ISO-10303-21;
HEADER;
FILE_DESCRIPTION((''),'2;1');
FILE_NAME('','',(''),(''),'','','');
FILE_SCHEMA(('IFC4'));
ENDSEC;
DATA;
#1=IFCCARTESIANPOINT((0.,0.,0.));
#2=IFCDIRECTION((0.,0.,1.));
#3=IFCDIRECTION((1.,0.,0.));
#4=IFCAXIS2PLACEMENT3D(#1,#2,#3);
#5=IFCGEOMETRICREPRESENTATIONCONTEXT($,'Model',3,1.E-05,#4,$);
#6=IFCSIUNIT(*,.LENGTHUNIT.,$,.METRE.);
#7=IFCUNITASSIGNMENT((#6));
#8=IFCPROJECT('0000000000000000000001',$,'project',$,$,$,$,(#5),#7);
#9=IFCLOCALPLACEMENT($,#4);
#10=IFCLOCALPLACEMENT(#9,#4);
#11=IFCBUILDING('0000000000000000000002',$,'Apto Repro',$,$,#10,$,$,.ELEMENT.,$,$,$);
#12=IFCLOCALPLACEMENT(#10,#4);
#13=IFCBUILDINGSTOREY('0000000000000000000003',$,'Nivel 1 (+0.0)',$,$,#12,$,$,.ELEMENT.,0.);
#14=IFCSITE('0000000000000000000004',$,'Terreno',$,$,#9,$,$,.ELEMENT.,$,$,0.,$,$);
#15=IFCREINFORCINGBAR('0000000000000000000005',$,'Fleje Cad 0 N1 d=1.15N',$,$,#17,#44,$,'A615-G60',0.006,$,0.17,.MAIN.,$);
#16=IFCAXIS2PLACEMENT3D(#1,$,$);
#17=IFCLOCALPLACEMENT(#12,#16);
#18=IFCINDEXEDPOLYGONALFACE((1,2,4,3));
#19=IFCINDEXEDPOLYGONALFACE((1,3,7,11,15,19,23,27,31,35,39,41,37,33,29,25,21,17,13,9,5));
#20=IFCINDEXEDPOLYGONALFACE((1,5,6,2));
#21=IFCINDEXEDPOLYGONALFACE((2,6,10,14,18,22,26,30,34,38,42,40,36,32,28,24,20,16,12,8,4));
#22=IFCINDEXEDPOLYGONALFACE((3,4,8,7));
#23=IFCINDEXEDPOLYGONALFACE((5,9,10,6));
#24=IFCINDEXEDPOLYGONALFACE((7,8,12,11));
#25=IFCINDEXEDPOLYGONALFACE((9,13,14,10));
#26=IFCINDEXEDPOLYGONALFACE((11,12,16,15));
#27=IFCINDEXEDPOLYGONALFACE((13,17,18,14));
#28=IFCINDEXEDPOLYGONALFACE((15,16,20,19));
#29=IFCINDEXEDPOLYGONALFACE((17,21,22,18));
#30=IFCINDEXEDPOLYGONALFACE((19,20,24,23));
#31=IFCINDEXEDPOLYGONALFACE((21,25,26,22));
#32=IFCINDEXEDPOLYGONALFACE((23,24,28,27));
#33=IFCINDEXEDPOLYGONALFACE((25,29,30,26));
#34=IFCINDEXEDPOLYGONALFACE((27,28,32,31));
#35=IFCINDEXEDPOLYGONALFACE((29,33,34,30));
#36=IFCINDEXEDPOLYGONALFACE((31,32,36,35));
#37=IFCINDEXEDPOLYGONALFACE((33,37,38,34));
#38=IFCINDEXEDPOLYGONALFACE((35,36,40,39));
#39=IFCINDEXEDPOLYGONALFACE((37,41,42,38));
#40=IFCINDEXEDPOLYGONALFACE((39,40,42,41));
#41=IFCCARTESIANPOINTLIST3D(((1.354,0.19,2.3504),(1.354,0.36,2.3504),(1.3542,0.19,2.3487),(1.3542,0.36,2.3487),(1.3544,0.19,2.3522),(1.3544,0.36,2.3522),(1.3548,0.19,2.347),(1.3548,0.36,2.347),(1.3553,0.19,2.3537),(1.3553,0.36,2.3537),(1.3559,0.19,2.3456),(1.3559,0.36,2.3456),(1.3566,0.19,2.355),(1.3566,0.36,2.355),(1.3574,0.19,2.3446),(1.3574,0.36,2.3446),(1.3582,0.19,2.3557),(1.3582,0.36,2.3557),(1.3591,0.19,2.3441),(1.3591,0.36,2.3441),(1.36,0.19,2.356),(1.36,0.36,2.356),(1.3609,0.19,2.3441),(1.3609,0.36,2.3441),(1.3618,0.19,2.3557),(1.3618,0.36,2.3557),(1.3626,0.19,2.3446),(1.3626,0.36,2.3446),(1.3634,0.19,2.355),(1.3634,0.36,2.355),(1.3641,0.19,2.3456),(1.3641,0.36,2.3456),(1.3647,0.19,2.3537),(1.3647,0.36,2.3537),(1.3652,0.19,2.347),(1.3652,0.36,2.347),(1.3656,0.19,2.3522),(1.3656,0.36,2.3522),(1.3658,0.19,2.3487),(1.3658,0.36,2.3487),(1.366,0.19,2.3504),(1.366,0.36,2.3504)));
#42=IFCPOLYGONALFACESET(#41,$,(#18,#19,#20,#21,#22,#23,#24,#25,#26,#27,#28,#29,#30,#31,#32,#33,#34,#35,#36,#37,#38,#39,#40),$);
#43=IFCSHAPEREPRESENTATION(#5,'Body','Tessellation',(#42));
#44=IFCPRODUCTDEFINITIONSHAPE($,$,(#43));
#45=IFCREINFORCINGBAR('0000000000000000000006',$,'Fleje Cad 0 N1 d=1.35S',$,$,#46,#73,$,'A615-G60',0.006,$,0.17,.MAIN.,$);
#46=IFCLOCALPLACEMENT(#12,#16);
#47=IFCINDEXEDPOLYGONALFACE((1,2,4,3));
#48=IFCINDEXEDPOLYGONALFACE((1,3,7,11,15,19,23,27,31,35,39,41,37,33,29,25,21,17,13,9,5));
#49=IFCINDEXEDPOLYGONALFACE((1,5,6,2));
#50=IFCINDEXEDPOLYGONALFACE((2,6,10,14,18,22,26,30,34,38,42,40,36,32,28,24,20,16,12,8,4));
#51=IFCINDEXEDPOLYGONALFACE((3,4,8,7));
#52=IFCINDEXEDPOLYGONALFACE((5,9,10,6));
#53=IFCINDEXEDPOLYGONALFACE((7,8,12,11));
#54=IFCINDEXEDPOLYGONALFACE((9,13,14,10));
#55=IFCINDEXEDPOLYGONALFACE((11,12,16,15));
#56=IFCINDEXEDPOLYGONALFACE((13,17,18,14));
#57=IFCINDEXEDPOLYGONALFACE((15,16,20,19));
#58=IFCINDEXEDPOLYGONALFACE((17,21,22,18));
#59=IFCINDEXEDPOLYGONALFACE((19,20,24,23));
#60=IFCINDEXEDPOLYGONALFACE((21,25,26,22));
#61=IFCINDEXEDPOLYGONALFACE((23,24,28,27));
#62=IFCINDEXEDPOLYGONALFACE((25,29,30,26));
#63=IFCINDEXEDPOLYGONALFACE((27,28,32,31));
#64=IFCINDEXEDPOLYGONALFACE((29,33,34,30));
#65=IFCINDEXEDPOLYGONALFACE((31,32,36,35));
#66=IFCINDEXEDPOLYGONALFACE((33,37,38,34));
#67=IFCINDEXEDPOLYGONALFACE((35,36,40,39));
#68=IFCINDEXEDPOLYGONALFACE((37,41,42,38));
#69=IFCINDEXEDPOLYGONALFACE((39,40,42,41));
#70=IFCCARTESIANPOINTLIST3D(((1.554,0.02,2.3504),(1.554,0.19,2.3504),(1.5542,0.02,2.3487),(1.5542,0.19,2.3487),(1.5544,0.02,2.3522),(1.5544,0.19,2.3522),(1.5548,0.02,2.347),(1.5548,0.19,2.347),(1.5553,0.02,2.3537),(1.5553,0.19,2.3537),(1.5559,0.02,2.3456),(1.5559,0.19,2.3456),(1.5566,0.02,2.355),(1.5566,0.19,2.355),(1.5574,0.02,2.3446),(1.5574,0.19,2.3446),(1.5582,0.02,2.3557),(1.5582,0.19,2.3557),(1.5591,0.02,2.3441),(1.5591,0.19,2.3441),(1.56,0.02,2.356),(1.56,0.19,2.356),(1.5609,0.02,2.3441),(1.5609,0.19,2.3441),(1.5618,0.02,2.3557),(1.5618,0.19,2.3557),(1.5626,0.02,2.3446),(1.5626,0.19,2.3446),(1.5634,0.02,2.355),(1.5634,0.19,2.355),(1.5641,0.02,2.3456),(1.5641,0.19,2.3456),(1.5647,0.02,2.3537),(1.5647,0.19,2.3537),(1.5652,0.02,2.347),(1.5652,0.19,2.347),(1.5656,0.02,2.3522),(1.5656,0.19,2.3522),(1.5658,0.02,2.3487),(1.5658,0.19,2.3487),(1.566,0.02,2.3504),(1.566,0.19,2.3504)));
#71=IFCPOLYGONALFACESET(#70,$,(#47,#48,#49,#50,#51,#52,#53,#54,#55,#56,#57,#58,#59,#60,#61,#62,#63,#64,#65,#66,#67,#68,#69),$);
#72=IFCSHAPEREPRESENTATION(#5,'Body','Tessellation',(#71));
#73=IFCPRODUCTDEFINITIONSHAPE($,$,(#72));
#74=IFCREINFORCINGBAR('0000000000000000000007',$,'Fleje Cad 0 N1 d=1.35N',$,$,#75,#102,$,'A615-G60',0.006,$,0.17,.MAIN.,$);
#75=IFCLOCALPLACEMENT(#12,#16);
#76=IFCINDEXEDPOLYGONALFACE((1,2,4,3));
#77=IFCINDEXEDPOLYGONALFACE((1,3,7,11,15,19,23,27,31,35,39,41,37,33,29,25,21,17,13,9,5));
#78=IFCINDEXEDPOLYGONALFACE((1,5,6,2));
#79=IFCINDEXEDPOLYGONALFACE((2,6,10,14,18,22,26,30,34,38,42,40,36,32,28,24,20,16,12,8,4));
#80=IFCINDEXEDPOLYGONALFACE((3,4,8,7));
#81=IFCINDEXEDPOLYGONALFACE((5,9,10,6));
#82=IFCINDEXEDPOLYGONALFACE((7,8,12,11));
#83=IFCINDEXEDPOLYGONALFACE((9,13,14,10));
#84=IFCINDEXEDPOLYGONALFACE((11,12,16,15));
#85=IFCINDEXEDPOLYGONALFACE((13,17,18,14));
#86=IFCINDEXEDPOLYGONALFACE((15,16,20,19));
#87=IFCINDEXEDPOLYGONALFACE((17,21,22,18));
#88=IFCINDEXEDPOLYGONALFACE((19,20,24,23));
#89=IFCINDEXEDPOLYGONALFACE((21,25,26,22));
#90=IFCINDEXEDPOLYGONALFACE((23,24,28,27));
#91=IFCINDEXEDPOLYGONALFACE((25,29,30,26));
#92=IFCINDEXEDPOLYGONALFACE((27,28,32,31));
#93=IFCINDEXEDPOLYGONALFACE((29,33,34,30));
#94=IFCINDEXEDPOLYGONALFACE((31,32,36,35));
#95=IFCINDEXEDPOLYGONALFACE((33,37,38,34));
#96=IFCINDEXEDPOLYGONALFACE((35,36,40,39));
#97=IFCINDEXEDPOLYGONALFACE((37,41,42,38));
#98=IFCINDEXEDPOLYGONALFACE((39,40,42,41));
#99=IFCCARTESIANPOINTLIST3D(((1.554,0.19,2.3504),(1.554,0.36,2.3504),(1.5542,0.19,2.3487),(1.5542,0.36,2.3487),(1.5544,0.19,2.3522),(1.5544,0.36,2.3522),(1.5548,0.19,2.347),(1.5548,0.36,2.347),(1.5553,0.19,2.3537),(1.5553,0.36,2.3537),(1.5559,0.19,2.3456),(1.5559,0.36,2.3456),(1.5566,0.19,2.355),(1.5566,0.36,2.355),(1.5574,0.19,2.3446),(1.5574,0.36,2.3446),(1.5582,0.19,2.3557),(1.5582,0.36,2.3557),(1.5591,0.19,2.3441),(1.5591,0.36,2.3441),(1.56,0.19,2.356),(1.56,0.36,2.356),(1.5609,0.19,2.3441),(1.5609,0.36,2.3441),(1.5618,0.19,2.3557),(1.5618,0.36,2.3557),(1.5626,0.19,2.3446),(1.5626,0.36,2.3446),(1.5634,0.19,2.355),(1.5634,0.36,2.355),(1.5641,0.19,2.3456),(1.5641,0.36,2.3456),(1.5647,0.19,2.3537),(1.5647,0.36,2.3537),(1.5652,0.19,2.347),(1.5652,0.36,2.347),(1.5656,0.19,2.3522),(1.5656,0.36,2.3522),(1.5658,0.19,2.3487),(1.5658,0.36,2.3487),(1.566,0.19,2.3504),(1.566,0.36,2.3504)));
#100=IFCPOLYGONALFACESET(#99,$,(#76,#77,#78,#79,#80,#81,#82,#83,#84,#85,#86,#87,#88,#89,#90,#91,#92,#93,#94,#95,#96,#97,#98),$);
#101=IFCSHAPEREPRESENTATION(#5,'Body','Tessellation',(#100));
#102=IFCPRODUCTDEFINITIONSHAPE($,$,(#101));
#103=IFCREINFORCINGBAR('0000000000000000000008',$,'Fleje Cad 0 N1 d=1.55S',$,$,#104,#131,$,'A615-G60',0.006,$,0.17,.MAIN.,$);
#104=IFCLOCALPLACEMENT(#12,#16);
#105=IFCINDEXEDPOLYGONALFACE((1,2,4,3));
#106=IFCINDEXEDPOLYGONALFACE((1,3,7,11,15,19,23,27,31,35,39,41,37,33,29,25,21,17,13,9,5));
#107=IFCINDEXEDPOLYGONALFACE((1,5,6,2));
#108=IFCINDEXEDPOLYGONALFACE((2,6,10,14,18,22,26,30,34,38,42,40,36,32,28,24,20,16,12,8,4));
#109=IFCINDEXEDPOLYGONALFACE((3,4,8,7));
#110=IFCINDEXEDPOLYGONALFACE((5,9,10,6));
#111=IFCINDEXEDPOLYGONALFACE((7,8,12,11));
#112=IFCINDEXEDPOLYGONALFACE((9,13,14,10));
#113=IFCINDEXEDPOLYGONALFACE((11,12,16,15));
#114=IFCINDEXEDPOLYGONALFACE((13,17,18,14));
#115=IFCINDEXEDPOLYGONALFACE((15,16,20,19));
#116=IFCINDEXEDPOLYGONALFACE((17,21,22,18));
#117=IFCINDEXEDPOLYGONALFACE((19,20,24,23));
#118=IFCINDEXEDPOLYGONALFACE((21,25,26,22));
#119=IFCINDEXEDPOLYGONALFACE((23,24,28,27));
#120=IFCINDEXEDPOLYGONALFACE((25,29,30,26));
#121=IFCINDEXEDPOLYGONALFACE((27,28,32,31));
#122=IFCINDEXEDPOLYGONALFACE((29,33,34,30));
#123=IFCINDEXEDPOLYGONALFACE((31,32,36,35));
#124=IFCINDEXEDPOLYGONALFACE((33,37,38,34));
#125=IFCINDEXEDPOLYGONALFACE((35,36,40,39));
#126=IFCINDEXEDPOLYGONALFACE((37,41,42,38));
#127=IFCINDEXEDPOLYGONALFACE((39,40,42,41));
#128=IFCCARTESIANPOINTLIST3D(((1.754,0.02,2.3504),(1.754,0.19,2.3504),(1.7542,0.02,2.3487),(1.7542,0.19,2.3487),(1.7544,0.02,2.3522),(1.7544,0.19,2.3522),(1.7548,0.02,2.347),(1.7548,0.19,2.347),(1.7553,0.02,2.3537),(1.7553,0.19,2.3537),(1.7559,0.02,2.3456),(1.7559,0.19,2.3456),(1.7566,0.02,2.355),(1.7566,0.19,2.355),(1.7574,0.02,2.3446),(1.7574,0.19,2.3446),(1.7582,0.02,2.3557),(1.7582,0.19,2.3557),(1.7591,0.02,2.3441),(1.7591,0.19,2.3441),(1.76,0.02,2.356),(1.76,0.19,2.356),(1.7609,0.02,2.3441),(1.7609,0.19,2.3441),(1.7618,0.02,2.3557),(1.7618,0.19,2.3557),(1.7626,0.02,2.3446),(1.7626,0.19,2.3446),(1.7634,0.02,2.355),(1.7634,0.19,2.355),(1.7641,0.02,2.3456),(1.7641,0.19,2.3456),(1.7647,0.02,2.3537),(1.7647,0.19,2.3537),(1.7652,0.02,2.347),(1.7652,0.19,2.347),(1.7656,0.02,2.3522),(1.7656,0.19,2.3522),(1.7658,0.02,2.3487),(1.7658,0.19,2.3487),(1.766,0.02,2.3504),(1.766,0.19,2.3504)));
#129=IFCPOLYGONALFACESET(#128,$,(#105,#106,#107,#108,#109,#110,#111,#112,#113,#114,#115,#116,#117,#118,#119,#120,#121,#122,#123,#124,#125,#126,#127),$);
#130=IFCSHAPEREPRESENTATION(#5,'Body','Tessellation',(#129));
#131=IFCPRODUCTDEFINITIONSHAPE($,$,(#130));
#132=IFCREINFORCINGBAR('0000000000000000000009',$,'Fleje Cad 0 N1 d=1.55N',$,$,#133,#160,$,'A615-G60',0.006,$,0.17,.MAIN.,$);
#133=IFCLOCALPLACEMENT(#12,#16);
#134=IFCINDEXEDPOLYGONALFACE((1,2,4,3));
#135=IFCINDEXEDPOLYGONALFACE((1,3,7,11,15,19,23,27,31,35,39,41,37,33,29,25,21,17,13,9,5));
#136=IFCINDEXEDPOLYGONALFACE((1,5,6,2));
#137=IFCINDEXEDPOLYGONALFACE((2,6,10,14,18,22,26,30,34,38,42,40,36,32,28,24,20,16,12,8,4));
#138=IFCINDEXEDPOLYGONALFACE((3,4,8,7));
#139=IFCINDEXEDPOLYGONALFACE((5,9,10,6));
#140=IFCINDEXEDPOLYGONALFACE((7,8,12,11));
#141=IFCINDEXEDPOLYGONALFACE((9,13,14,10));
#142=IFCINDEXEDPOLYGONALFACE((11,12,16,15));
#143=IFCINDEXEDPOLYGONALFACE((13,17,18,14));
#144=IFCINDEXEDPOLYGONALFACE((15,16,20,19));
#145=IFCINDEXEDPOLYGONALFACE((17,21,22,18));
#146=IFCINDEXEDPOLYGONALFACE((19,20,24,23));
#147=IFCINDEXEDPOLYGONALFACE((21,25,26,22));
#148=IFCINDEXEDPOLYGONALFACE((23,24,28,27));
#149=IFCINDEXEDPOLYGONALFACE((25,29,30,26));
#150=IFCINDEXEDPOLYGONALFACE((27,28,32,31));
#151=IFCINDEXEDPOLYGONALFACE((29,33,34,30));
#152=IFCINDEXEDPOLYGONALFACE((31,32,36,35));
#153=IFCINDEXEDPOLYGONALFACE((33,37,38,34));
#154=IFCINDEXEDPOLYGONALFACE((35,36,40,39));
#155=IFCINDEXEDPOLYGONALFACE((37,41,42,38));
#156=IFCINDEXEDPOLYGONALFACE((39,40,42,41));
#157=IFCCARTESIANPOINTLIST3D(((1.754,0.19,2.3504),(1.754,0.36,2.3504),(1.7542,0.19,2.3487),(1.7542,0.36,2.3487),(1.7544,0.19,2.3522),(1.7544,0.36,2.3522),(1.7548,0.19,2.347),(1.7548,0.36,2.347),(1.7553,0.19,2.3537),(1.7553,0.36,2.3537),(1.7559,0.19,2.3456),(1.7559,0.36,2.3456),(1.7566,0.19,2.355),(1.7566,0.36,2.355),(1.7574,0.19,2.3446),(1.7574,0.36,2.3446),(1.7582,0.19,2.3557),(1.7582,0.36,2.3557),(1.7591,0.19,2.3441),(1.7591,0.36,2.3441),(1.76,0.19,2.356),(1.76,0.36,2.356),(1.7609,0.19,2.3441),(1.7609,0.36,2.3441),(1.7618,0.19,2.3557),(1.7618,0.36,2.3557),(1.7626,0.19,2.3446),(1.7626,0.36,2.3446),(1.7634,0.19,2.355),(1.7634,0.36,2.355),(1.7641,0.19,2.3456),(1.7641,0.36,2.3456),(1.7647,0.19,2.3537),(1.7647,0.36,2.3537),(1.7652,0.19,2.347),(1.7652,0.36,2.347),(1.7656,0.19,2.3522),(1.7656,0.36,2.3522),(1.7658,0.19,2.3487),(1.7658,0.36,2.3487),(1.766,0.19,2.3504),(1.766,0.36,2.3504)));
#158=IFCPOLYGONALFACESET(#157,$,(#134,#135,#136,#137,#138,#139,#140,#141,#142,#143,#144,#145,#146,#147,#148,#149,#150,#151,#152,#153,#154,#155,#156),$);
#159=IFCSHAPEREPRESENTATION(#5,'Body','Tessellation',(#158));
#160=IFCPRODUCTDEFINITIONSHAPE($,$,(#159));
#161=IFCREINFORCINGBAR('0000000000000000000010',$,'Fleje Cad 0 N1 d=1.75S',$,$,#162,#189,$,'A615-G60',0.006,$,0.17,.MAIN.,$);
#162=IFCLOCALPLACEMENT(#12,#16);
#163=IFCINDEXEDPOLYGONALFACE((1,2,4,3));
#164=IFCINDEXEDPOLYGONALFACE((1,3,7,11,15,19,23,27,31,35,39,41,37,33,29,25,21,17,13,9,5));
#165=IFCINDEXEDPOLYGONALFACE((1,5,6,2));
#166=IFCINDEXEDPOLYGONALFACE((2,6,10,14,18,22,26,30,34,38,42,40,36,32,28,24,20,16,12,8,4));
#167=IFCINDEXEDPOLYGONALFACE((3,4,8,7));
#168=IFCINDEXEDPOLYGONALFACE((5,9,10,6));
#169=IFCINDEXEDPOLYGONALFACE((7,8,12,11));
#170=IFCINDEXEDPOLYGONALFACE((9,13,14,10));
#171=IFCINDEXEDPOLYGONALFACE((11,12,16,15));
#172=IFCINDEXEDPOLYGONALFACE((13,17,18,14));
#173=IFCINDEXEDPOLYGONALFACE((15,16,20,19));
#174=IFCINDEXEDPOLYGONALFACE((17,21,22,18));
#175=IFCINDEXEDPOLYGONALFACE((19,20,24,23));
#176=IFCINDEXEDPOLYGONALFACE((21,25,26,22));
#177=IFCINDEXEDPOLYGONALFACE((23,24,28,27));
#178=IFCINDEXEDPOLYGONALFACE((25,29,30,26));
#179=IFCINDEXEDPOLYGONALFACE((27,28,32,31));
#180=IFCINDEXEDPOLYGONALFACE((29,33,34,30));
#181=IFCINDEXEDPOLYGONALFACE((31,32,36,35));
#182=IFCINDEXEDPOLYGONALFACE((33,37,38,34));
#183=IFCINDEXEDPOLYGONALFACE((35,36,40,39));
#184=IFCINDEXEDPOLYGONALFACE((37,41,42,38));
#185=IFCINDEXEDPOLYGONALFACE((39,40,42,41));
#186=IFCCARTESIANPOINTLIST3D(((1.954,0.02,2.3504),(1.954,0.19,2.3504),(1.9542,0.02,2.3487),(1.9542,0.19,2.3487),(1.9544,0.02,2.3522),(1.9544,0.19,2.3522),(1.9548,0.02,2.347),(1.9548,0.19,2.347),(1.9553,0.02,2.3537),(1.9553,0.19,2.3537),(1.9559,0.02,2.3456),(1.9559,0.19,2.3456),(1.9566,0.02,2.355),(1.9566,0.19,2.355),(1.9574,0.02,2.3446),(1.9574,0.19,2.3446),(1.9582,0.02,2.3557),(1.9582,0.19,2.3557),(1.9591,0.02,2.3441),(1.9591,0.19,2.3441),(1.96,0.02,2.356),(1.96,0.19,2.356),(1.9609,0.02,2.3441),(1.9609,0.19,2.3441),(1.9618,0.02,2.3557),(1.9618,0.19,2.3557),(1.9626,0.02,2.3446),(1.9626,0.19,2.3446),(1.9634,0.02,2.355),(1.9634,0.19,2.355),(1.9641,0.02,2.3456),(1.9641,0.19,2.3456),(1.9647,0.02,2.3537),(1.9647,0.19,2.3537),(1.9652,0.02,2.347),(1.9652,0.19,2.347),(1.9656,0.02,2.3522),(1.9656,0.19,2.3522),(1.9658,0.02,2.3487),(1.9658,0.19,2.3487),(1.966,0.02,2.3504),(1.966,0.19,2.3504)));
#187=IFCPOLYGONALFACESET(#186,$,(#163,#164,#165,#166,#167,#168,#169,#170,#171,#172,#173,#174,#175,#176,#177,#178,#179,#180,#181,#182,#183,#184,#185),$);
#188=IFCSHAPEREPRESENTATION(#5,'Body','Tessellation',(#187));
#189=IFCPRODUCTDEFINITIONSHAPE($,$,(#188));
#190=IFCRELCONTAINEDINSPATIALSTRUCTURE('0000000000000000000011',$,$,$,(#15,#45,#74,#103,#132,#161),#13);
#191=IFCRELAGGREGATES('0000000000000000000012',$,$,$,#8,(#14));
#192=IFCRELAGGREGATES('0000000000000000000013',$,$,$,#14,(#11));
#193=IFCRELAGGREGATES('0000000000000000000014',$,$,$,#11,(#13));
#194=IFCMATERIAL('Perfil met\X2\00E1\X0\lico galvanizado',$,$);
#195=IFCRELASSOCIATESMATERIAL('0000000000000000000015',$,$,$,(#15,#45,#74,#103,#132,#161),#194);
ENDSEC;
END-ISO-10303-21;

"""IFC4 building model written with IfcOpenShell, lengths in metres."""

from ifc_helpers import new_model, si_unit, frame, origin_with_axes, origin_2d_with_axis, place, context, project, spatial, circle, extrude, material, element, save


model = new_model("IFC4")

# Units and contexts
model_context = context("Model", 3, precision=1e-05, world=origin_with_axes())
ifc_project = project(units=[si_unit("LENGTHUNIT", "METRE")], contexts=[model_context])

# Site, building, storey
site_placement = place(None, origin_with_axes())
site = spatial("IfcSite", under=ifc_project, at=site_placement, Name="Terreno", CompositionType="ELEMENT", RefElevation=0.0)
building_placement = place(site_placement, origin_with_axes())
building = spatial("IfcBuilding", under=site, at=building_placement, Name="Apto Repro", CompositionType="ELEMENT")
storey_placement = place(building_placement, origin_with_axes())
storey = spatial("IfcBuildingStorey", under=building, at=storey_placement, Name="Nivel 1 (+0.0)", CompositionType="ELEMENT", Elevation=0.0)

# Reinforcing bars
ifc_material = material(Name="Perfil metálico galvanizado")
reinforcing_bar_1_placement = place(storey_placement, origin_with_axes())
element("IfcReinforcingBar", 1, at=reinforcing_bar_1_placement, inside=storey, material=ifc_material, Name="Fleje Cad 0 N1 d=1.15N", SteelGrade="A615-G60", BarLength=0.17, NominalDiameter=0.006, PredefinedType="MAIN", context=model_context, shape_type="SweptSolid", body=[
    extrude(circle(Radius=0.006, at=origin_2d_with_axis()), frame((1.36, 0.19, 2.35), z_axis=(0.0, 1.0, 0.0), x_axis=(0.0, 0.0, 1.0)), (0.0, 0.0, 1.0), 0.17),
])
reinforcing_bar_2_placement = place(storey_placement, origin_with_axes())
element("IfcReinforcingBar", 2, at=reinforcing_bar_2_placement, inside=storey, material=ifc_material, Name="Fleje Cad 0 N1 d=1.35S", SteelGrade="A615-G60", BarLength=0.17, NominalDiameter=0.006, PredefinedType="MAIN", context=model_context, shape_type="SweptSolid", body=[
    extrude(circle(Radius=0.006, at=origin_2d_with_axis()), frame((1.56, 0.02, 2.35), z_axis=(0.0, 1.0, 0.0), x_axis=(0.0, 0.0, 1.0)), (0.0, 0.0, 1.0), 0.17),
])
reinforcing_bar_3_placement = place(storey_placement, origin_with_axes())
element("IfcReinforcingBar", 3, at=reinforcing_bar_3_placement, inside=storey, material=ifc_material, Name="Fleje Cad 0 N1 d=1.35N", SteelGrade="A615-G60", BarLength=0.17, NominalDiameter=0.006, PredefinedType="MAIN", context=model_context, shape_type="SweptSolid", body=[
    extrude(circle(Radius=0.006, at=origin_2d_with_axis()), frame((1.56, 0.19, 2.35), z_axis=(0.0, 1.0, 0.0), x_axis=(0.0, 0.0, 1.0)), (0.0, 0.0, 1.0), 0.17),
])
reinforcing_bar_4_placement = place(storey_placement, origin_with_axes())
element("IfcReinforcingBar", 4, at=reinforcing_bar_4_placement, inside=storey, material=ifc_material, Name="Fleje Cad 0 N1 d=1.55S", SteelGrade="A615-G60", BarLength=0.17, NominalDiameter=0.006, PredefinedType="MAIN", context=model_context, shape_type="SweptSolid", body=[
    extrude(circle(Radius=0.006, at=origin_2d_with_axis()), frame((1.76, 0.02, 2.35), z_axis=(0.0, 1.0, 0.0), x_axis=(0.0, 0.0, 1.0)), (0.0, 0.0, 1.0), 0.17),
])
reinforcing_bar_5_placement = place(storey_placement, origin_with_axes())
element("IfcReinforcingBar", 5, at=reinforcing_bar_5_placement, inside=storey, material=ifc_material, Name="Fleje Cad 0 N1 d=1.55N", SteelGrade="A615-G60", BarLength=0.17, NominalDiameter=0.006, PredefinedType="MAIN", context=model_context, shape_type="SweptSolid", body=[
    extrude(circle(Radius=0.006, at=origin_2d_with_axis()), frame((1.76, 0.19, 2.35), z_axis=(0.0, 1.0, 0.0), x_axis=(0.0, 0.0, 1.0)), (0.0, 0.0, 1.0), 0.17),
])
reinforcing_bar_6_placement = place(storey_placement, origin_with_axes())
element("IfcReinforcingBar", 6, at=reinforcing_bar_6_placement, inside=storey, material=ifc_material, Name="Fleje Cad 0 N1 d=1.75S", SteelGrade="A615-G60", BarLength=0.17, NominalDiameter=0.006, PredefinedType="MAIN", context=model_context, shape_type="SweptSolid", body=[
    extrude(circle(Radius=0.006, at=origin_2d_with_axis()), frame((1.96, 0.02, 2.35), z_axis=(0.0, 1.0, 0.0), x_axis=(0.0, 0.0, 1.0)), (0.0, 0.0, 1.0), 0.17),
])

save(model, "model.ifc")
